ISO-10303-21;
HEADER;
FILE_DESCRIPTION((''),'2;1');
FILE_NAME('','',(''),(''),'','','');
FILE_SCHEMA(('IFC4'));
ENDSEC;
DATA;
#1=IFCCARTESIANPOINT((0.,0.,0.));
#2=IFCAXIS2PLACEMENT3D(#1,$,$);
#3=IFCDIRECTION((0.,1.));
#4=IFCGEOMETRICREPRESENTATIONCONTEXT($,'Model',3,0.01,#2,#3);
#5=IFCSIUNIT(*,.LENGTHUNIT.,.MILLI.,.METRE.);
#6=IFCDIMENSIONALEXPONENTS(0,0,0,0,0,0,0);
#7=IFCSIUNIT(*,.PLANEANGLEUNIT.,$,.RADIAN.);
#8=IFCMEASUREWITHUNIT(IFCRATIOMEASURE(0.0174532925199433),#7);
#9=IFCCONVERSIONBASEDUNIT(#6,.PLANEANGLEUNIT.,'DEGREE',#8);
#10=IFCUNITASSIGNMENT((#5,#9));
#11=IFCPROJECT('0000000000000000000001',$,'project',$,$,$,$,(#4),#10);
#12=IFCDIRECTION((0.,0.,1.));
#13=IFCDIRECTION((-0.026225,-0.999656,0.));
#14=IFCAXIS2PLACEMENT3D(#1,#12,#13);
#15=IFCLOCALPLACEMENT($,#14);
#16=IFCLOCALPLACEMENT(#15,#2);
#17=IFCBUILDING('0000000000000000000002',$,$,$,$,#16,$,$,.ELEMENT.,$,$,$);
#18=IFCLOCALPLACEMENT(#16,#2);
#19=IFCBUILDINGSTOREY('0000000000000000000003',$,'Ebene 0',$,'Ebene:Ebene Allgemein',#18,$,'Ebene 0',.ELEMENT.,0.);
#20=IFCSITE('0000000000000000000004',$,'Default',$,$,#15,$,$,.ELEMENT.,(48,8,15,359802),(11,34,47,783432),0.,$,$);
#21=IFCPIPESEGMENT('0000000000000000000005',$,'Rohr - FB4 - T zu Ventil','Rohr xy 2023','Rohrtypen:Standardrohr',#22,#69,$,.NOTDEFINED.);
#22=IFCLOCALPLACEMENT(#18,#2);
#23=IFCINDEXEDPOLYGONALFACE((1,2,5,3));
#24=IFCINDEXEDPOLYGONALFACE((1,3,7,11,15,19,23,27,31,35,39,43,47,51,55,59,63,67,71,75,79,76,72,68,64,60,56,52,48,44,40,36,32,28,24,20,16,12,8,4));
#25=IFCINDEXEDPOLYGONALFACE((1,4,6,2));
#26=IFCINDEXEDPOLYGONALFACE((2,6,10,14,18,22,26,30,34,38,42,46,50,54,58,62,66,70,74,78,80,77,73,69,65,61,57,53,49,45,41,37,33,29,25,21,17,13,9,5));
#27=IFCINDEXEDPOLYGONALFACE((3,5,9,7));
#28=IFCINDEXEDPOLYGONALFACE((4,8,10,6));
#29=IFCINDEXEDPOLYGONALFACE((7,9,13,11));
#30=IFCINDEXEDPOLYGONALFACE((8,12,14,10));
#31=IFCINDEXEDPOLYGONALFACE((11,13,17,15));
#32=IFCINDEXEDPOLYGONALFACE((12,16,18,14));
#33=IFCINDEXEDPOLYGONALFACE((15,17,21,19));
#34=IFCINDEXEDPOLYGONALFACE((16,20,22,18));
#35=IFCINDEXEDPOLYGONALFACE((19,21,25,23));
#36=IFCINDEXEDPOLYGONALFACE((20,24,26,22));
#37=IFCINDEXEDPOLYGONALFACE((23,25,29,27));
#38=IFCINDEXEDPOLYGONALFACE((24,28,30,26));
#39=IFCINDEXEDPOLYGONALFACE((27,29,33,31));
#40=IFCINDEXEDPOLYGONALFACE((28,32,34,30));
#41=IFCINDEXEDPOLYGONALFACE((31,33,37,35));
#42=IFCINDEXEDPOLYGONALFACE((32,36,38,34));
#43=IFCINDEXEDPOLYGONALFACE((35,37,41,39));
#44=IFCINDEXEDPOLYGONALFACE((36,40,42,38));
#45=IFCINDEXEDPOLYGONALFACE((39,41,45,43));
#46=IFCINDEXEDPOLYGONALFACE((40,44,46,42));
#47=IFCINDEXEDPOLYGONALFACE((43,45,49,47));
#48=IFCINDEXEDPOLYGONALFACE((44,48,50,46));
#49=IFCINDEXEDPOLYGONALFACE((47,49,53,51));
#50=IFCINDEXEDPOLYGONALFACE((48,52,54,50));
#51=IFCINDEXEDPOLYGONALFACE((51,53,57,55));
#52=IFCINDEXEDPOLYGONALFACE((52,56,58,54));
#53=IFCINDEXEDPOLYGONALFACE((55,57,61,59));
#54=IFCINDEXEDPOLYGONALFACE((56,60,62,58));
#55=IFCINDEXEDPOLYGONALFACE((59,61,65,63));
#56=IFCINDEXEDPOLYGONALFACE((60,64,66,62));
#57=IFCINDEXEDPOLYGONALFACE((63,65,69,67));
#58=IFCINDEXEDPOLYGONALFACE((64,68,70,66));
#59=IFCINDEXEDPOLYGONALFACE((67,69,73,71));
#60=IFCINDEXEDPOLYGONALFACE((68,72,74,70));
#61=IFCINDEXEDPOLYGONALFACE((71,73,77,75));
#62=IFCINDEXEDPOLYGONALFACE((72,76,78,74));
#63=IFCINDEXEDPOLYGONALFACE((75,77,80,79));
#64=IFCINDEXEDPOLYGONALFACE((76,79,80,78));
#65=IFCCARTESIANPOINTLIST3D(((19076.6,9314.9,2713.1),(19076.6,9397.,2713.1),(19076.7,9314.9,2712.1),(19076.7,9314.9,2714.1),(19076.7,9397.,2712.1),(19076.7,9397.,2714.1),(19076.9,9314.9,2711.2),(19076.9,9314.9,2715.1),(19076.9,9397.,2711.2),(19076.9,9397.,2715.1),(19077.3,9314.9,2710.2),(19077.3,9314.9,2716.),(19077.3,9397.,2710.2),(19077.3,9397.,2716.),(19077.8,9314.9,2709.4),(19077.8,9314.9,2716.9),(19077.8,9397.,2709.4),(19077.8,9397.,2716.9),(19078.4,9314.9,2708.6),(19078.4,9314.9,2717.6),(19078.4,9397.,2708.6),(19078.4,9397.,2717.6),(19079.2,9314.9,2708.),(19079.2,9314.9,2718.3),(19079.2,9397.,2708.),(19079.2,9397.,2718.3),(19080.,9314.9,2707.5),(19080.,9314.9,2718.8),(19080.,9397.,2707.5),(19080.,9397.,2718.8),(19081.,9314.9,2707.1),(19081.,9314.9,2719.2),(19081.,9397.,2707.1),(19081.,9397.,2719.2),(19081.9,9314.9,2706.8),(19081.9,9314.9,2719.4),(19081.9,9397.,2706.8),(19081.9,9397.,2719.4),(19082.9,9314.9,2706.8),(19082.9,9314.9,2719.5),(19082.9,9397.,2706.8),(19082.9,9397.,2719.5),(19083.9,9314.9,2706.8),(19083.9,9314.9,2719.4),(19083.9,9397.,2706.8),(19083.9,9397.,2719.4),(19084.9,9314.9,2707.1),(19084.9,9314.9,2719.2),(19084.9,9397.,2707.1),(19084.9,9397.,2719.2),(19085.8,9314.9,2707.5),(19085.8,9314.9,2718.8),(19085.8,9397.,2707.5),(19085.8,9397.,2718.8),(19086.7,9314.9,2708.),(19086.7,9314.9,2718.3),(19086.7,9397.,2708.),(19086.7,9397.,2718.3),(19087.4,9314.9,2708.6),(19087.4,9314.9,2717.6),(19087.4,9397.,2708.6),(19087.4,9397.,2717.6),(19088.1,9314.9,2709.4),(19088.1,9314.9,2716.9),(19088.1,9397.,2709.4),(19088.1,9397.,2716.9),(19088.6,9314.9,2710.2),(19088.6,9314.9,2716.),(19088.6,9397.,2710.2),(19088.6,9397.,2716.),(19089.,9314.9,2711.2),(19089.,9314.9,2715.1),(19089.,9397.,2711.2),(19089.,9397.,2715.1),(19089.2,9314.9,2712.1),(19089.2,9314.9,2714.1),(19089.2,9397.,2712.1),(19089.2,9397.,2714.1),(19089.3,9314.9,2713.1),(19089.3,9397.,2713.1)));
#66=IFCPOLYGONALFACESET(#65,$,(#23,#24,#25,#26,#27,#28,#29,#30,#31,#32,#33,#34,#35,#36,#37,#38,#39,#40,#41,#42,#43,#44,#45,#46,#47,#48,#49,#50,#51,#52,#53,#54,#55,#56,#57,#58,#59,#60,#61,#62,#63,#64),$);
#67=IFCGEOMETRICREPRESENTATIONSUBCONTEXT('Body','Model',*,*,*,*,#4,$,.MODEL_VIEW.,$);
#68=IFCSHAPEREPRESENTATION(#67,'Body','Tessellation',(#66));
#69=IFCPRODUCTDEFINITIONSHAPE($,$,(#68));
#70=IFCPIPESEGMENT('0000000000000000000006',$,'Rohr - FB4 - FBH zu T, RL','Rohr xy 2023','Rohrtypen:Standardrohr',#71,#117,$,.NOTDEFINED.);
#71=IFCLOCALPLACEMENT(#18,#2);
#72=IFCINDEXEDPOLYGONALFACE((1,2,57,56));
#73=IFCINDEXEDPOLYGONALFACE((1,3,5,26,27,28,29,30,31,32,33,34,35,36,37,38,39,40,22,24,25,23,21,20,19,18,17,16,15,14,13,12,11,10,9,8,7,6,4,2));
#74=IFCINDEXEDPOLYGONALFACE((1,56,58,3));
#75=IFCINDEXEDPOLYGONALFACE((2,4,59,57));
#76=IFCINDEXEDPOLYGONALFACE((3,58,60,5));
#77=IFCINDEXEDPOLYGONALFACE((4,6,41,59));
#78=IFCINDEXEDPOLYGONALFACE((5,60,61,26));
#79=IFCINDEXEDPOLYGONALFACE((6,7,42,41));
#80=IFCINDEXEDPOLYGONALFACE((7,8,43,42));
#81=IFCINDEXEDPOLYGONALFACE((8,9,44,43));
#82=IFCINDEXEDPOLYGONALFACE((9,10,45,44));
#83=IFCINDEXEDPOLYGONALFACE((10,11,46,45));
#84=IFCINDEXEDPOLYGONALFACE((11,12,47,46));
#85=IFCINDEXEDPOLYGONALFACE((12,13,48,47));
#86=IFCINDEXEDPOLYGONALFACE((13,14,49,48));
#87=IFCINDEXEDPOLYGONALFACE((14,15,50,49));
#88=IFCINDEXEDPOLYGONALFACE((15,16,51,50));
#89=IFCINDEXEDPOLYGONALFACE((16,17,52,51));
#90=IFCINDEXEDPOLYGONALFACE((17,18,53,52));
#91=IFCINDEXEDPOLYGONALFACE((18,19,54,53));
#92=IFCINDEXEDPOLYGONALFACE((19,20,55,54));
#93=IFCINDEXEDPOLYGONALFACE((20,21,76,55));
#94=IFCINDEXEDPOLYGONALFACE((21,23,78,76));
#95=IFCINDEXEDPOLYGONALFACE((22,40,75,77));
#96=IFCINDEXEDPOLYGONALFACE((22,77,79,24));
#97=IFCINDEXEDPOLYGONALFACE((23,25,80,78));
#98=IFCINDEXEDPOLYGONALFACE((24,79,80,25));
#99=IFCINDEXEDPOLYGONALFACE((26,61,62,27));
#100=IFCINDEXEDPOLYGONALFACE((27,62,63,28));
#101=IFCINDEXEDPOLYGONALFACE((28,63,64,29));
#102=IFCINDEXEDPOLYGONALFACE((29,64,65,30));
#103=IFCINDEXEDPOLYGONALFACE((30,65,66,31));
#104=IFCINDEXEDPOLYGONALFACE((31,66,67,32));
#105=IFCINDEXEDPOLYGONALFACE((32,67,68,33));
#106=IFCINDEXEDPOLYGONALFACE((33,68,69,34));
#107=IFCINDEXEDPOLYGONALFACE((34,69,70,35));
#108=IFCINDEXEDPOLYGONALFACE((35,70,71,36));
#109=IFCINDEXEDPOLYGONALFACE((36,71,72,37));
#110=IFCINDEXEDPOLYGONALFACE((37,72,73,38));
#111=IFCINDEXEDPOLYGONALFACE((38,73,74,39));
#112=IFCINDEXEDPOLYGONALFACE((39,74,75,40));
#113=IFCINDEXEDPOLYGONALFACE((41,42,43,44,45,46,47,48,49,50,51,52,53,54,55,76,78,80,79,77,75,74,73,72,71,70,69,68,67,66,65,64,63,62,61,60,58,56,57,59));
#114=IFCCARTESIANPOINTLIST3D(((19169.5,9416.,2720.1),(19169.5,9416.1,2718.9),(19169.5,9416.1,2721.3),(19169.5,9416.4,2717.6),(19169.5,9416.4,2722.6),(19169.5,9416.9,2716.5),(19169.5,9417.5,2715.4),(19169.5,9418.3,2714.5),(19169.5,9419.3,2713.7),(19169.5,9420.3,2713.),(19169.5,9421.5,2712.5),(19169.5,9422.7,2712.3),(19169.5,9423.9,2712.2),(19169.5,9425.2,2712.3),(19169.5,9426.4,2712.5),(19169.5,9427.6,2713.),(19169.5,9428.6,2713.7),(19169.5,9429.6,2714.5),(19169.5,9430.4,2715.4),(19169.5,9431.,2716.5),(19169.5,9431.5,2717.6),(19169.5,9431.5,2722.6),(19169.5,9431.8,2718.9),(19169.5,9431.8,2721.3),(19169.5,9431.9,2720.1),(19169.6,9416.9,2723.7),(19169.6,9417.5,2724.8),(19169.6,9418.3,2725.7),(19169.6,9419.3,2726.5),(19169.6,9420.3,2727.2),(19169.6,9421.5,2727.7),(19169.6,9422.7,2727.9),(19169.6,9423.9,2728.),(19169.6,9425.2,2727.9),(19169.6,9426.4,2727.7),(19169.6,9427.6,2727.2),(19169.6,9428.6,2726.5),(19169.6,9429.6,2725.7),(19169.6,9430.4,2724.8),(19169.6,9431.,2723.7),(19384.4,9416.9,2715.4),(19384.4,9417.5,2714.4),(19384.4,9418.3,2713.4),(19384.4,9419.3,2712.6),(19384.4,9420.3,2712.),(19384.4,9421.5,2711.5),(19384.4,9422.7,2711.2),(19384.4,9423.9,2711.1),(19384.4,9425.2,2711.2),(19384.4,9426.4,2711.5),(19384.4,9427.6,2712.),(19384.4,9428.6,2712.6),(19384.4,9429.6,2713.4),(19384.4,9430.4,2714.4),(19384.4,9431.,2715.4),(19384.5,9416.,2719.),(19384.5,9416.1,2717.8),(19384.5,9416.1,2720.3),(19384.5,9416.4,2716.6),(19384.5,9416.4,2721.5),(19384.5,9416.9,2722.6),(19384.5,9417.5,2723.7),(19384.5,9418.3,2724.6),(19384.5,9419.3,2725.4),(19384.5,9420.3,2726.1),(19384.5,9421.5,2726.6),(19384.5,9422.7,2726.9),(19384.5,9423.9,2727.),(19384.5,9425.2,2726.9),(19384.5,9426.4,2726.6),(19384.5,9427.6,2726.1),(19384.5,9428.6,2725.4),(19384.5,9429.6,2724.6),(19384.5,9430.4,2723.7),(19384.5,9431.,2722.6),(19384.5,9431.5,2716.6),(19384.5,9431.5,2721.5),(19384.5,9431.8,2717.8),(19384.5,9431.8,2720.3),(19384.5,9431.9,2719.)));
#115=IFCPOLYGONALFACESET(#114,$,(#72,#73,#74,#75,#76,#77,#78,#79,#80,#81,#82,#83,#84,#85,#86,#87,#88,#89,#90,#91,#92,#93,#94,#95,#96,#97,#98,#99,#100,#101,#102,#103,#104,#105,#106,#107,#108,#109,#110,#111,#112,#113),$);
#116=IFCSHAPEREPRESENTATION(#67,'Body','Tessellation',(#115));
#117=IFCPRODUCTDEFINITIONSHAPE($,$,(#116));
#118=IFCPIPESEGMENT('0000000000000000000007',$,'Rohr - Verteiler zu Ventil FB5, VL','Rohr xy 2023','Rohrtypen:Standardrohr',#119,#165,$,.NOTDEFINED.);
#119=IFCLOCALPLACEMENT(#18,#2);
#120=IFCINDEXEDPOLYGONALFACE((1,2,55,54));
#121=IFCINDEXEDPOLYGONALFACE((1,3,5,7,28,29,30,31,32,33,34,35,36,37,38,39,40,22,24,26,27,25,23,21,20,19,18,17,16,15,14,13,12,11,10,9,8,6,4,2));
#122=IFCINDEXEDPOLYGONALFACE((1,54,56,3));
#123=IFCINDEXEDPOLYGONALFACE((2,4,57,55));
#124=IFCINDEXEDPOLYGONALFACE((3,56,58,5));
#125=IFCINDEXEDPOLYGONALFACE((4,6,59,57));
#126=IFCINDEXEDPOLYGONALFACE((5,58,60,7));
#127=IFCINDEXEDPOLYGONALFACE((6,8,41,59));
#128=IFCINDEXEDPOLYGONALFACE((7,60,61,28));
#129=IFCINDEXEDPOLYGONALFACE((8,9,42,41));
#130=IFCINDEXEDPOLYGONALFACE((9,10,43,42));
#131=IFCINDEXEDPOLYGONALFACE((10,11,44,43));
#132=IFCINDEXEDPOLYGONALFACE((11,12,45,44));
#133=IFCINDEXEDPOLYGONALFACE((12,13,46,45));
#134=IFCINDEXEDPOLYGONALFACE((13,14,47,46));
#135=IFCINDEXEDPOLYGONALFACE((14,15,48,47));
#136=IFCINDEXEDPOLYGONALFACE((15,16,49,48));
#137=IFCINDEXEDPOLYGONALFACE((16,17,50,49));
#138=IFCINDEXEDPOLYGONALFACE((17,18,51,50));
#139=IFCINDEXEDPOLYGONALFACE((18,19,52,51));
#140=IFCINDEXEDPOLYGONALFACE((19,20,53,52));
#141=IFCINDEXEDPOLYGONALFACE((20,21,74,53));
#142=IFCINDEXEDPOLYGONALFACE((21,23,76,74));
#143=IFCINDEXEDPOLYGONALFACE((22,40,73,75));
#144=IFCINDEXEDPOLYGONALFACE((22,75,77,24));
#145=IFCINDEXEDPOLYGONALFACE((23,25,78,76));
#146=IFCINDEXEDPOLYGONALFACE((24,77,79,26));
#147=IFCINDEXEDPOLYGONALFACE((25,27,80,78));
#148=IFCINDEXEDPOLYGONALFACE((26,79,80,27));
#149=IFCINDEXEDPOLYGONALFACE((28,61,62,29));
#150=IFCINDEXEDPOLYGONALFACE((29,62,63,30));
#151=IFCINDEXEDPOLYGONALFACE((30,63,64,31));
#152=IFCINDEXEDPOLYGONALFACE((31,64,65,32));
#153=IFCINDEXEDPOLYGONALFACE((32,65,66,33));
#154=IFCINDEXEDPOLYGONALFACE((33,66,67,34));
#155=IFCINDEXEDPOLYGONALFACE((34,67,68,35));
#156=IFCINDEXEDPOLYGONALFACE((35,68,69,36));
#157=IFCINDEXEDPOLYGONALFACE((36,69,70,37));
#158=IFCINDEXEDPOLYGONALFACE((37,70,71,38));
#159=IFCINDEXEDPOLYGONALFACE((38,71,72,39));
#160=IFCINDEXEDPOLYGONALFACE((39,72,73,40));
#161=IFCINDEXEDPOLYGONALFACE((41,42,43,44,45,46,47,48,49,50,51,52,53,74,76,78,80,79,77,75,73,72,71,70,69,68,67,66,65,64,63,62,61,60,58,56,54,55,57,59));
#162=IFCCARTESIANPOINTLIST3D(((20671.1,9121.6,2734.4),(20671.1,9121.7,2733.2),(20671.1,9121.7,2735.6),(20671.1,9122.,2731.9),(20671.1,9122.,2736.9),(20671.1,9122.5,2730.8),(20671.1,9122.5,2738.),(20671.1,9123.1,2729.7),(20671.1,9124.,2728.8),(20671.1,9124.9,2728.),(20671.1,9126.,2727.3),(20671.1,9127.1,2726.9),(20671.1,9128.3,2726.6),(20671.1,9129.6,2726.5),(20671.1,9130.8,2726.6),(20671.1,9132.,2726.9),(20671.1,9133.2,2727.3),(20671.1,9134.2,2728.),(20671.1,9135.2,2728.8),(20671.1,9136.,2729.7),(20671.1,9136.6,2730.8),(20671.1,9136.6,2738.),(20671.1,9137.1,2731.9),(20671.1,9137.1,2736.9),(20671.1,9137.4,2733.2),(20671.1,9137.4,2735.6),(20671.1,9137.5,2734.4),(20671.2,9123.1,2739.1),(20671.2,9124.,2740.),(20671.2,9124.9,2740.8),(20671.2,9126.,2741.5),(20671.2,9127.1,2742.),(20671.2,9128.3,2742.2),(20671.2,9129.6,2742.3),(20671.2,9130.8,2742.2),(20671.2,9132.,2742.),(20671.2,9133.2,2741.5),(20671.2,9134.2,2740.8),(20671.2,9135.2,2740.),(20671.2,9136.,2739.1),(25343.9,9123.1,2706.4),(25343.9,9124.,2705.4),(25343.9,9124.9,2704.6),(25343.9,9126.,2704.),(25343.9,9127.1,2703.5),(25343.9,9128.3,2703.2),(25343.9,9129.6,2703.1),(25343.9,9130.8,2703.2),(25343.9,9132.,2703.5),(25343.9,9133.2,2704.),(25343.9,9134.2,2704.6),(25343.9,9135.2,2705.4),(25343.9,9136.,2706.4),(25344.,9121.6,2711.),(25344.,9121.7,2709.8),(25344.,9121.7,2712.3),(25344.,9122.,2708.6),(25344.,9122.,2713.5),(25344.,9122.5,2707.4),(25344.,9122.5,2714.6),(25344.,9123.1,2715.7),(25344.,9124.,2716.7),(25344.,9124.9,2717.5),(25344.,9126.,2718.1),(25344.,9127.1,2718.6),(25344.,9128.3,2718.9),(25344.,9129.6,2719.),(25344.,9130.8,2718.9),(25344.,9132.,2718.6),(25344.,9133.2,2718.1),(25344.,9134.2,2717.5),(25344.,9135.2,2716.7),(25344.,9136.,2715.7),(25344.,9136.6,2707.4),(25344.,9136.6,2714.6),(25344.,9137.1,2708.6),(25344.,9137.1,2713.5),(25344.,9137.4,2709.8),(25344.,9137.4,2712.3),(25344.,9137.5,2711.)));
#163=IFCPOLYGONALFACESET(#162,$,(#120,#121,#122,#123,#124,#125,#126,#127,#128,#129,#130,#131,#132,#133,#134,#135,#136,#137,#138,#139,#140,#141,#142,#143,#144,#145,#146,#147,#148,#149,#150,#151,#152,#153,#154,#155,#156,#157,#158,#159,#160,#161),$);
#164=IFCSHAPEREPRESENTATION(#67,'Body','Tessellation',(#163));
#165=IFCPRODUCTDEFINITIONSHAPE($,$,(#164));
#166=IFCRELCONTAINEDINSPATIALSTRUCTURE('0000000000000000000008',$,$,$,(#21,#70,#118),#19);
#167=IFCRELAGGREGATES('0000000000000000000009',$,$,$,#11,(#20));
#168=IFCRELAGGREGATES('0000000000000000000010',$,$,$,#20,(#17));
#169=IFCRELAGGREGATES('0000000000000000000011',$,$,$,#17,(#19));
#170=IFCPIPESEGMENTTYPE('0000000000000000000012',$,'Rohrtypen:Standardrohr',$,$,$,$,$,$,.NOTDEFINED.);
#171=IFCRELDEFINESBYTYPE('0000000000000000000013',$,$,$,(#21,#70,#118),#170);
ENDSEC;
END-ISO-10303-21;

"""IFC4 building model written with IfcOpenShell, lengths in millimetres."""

from ifc_helpers import new_model, entity, si_unit, converted_unit, direction, frame, origin, place, context, subcontext, project, spatial, indexed_curve, outline, extrude, type_object, element, save


model = new_model("IFC4")

# Units and contexts
model_context = context("Model", 3, precision=0.01, world=origin(), true_north=direction((0.0, 1.0)))
body_context = subcontext(model_context, "Body", "Model", "MODEL_VIEW")
ifc_project = project(units=[si_unit("LENGTHUNIT", "METRE", prefix="MILLI"), converted_unit("PLANEANGLEUNIT", "DEGREE", entity("IfcRatioMeasure", 0.0174532925199433), si_unit("PLANEANGLEUNIT", "RADIAN"), dimensions=[0, 0, 0, 0, 0, 0, 0])], contexts=[model_context])

# Site, building, storey
site_placement = place(None, frame((0.0, 0.0, 0.0), z_axis=(0.0, 0.0, 1.0), x_axis=(-0.026225, -0.999656, 0.0)))
site = spatial("IfcSite", under=ifc_project, at=site_placement, Name="Default", CompositionType="ELEMENT", RefLatitude=(48, 8, 15, 359802), RefLongitude=(11, 34, 47, 783432), RefElevation=0.0)
building_placement = place(site_placement, origin())
building = spatial("IfcBuilding", under=site, at=building_placement, CompositionType="ELEMENT")
storey_placement = place(building_placement, origin())
storey = spatial("IfcBuildingStorey", under=building, at=storey_placement, Name="Ebene 0", ObjectType="Ebene:Ebene Allgemein", LongName="Ebene 0", CompositionType="ELEMENT", Elevation=0.0)

# Pipe segments
pipe_segment_type = type_object("IfcPipeSegmentType", Name="Rohrtypen:Standardrohr", PredefinedType="NOTDEFINED")
pipe_segment_1_placement = place(storey_placement, origin())
element("IfcPipeSegment", 1, at=pipe_segment_1_placement, inside=storey, type_object=pipe_segment_type, Name="Rohr - FB4 - T zu Ventil", Description="Rohr xy 2023", ObjectType="Rohrtypen:Standardrohr", PredefinedType="NOTDEFINED", context=body_context, shape_type="SweptSolid", body=[
    extrude(outline(indexed_curve([(6.4, 0.0), (6.3, 1.0), (6.0, 2.0), (5.7, 2.9), (5.1, 3.7), (4.5, 4.5), (3.7, 5.1), (2.9, 5.7), (2.0, 6.0), (1.0, 6.3), (0.0, 6.4), (-1.0, 6.3), (-2.0, 6.0), (-2.9, 5.7), (-3.7, 5.1), (-4.5, 4.5), (-5.1, 3.7), (-5.7, 2.9), (-6.0, 2.0), (-6.3, 1.0), (-6.4, 0.0), (-6.3, -1.0), (-6.0, -2.0), (-5.7, -2.9), (-5.1, -3.7), (-4.5, -4.5), (-3.7, -5.1), (-2.9, -5.7), (-2.0, -6.0), (-1.0, -6.3), (0.0, -6.4), (1.0, -6.3), (2.0, -6.0), (2.9, -5.7), (3.7, -5.1), (4.5, -4.5), (5.1, -3.7), (5.7, -2.9), (6.0, -2.0), (6.3, -1.0), (6.4, 0.0)], self_intersect=False)), frame((19082.9, 9314.9, 2713.1), z_axis=(0.0, 1.0, 0.0), x_axis=(-1.0, 0.0, 0.0)), (0.0, 0.0, 1.0), 82.2),
])
pipe_segment_2_placement = place(storey_placement, origin())
element("IfcPipeSegment", 2, at=pipe_segment_2_placement, inside=storey, type_object=pipe_segment_type, Name="Rohr - FB4 - FBH zu T, RL", Description="Rohr xy 2023", ObjectType="Rohrtypen:Standardrohr", PredefinedType="NOTDEFINED", context=body_context, shape_type="SweptSolid", body=[
    extrude(outline(indexed_curve([(7.9, 0.0), (7.8, 1.2), (7.6, 2.5), (7.1, 3.6), (6.4, 4.7), (5.6, 5.6), (4.7, 6.4), (3.6, 7.1), (2.5, 7.6), (1.2, 7.8), (0.0, 7.9), (-1.2, 7.8), (-2.5, 7.6), (-3.6, 7.1), (-4.7, 6.4), (-5.6, 5.6), (-6.4, 4.7), (-7.1, 3.6), (-7.6, 2.5), (-7.8, 1.2), (-7.9, 0.0), (-7.8, -1.2), (-7.6, -2.5), (-7.1, -3.6), (-6.4, -4.7), (-5.6, -5.6), (-4.7, -6.4), (-3.6, -7.1), (-2.5, -7.6), (-1.2, -7.8), (0.0, -7.9), (1.2, -7.8), (2.5, -7.6), (3.6, -7.1), (4.7, -6.4), (5.6, -5.6), (6.4, -4.7), (7.1, -3.6), (7.6, -2.5), (7.8, -1.2), (7.9, 0.0)], self_intersect=False)), frame((19384.5, 9423.9, 2719.0), z_axis=(-0.999988, 0.0, 0.005), x_axis=(0.0, 1.0, 0.0)), (0.0, 0.0, 1.0), 214.9),
])
pipe_segment_3_placement = place(storey_placement, origin())
element("IfcPipeSegment", 3, at=pipe_segment_3_placement, inside=storey, type_object=pipe_segment_type, Name="Rohr - Verteiler zu Ventil FB5, VL", Description="Rohr xy 2023", ObjectType="Rohrtypen:Standardrohr", PredefinedType="NOTDEFINED", context=body_context, shape_type="SweptSolid", body=[
    extrude(outline(indexed_curve([(7.9, 0.0), (7.8, 1.2), (7.6, 2.5), (7.1, 3.6), (6.4, 4.7), (5.6, 5.6), (4.7, 6.4), (3.6, 7.1), (2.5, 7.6), (1.2, 7.8), (0.0, 7.9), (-1.2, 7.8), (-2.5, 7.6), (-3.6, 7.1), (-4.7, 6.4), (-5.6, 5.6), (-6.4, 4.7), (-7.1, 3.6), (-7.6, 2.5), (-7.8, 1.2), (-7.9, 0.0), (-7.8, -1.2), (-7.6, -2.5), (-7.1, -3.6), (-6.4, -4.7), (-5.6, -5.6), (-4.7, -6.4), (-3.6, -7.1), (-2.5, -7.6), (-1.2, -7.8), (0.0, -7.9), (1.2, -7.8), (2.5, -7.6), (3.6, -7.1), (4.7, -6.4), (5.6, -5.6), (6.4, -4.7), (7.1, -3.6), (7.6, -2.5), (7.8, -1.2), (7.9, 0.0)], self_intersect=False)), frame((25344.0, 9129.6, 2711.0), z_axis=(-0.999988, 0.0, 0.005), x_axis=(0.0, 1.0, 0.0)), (0.0, 0.0, 1.0), 4672.9),
])

save(model, "model.ifc")
